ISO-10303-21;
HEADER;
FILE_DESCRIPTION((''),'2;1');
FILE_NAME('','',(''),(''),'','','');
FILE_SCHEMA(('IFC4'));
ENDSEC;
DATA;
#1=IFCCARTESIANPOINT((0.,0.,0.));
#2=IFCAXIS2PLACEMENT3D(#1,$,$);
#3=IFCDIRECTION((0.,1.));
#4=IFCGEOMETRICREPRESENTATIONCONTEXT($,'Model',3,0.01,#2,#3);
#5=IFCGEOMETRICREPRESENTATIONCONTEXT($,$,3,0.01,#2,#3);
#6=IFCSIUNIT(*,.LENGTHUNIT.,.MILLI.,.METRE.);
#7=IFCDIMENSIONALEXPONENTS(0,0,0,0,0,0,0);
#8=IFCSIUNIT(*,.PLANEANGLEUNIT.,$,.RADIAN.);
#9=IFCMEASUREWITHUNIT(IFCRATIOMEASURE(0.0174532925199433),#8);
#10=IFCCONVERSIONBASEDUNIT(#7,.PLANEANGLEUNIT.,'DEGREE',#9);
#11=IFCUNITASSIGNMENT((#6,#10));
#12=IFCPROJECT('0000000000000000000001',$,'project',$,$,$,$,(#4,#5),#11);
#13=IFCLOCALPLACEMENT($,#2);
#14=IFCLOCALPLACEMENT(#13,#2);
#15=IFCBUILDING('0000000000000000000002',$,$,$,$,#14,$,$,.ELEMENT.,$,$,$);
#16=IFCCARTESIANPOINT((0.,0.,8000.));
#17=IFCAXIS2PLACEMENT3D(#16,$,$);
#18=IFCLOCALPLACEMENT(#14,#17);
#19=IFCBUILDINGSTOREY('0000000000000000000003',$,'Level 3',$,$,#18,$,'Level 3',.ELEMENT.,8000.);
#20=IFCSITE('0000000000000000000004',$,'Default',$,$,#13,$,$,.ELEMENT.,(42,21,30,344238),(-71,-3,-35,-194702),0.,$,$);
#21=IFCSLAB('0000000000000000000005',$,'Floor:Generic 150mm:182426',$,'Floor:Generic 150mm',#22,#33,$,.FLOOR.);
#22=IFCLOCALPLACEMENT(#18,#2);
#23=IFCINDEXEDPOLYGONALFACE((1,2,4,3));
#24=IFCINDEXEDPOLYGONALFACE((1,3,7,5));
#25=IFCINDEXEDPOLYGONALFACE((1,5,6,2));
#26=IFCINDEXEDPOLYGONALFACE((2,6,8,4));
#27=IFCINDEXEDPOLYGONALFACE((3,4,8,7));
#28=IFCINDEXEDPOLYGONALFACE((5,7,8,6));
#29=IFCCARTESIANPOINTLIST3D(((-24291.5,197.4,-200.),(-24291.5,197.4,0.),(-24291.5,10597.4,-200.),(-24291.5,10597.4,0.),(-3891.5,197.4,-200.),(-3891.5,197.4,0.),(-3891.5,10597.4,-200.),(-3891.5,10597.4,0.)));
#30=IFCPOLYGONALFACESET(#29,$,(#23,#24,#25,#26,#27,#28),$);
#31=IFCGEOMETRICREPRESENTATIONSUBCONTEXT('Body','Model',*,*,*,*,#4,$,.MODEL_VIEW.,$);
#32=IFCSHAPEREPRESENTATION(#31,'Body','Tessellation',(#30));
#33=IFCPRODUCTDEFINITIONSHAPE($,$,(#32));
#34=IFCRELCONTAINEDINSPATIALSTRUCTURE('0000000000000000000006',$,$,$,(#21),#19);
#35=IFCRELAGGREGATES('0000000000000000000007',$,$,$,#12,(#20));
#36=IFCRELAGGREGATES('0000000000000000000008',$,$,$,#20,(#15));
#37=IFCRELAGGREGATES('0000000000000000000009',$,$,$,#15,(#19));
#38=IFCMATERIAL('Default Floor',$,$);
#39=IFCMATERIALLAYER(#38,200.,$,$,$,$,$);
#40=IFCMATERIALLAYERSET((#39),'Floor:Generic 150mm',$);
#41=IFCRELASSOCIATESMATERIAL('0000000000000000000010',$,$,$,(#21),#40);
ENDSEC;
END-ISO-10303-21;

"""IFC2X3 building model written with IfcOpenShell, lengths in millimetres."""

from ifc_helpers import new_model, entity, si_unit, converted_unit, direction, frame, origin, origin_2d_with_axis, place, context, subcontext, project, spatial, rectangle, extrude, material, layer, layer_set, layer_usage, element, save


model = new_model("IFC2X3")

# Units and contexts
model_context = context("Model", 3, precision=0.01, world=origin(), true_north=direction((0.0, 1.0)))
context_of_model = context(None, 3, precision=0.01, world=origin(), true_north=direction((0.0, 1.0)))
body_context = subcontext(model_context, "Body", "Model", "MODEL_VIEW")
ifc_project = project(units=[si_unit("LENGTHUNIT", "METRE", prefix="MILLI"), converted_unit("PLANEANGLEUNIT", "DEGREE", entity("IfcRatioMeasure", 0.0174532925199433), si_unit("PLANEANGLEUNIT", "RADIAN"), dimensions=[0, 0, 0, 0, 0, 0, 0])], contexts=[model_context, context_of_model])

# Site, building, storey
site_placement = place(None, origin())
site = spatial("IfcSite", under=ifc_project, at=site_placement, Name="Default", CompositionType="ELEMENT", RefLatitude=(42, 21, 30, 344238), RefLongitude=(-71, -3, -35, -194702), RefElevation=0.0)
building_placement = place(site_placement, origin())
building = spatial("IfcBuilding", under=site, at=building_placement, CompositionType="ELEMENT")
storey_placement = place(building_placement, frame((0.0, 0.0, 8000.0)))
storey = spatial("IfcBuildingStorey", under=building, at=storey_placement, Name="Level 3", LongName="Level 3", CompositionType="ELEMENT", Elevation=8000.0)

# Slab
ifc_material = material(Name="Default Floor")
ifc_layer = layer(ifc_material, 200.0)
ifc_layer_set = layer_set([ifc_layer], Name="Floor:Generic 150mm")
ifc_layer_usage = layer_usage(ifc_layer_set, "AXIS3", "POSITIVE", 0.0)
slab_placement = place(storey_placement, origin())
element("IfcSlab", 1, at=slab_placement, inside=storey, material=ifc_layer_usage, Name="Floor:Generic 150mm:182426", ObjectType="Floor:Generic 150mm", PredefinedType="FLOOR", context=body_context, shape_type="SweptSolid", body=[
    extrude(rectangle(XDim=10400.0, YDim=20400.0, at=origin_2d_with_axis()), frame((-14091.5, 5397.4, 0.0), z_axis=(0.0, 0.0, -1.0), x_axis=(0.0, 1.0, 0.0)), (0.0, 0.0, 1.0), 200.0),
])

save(model, "model.ifc")
